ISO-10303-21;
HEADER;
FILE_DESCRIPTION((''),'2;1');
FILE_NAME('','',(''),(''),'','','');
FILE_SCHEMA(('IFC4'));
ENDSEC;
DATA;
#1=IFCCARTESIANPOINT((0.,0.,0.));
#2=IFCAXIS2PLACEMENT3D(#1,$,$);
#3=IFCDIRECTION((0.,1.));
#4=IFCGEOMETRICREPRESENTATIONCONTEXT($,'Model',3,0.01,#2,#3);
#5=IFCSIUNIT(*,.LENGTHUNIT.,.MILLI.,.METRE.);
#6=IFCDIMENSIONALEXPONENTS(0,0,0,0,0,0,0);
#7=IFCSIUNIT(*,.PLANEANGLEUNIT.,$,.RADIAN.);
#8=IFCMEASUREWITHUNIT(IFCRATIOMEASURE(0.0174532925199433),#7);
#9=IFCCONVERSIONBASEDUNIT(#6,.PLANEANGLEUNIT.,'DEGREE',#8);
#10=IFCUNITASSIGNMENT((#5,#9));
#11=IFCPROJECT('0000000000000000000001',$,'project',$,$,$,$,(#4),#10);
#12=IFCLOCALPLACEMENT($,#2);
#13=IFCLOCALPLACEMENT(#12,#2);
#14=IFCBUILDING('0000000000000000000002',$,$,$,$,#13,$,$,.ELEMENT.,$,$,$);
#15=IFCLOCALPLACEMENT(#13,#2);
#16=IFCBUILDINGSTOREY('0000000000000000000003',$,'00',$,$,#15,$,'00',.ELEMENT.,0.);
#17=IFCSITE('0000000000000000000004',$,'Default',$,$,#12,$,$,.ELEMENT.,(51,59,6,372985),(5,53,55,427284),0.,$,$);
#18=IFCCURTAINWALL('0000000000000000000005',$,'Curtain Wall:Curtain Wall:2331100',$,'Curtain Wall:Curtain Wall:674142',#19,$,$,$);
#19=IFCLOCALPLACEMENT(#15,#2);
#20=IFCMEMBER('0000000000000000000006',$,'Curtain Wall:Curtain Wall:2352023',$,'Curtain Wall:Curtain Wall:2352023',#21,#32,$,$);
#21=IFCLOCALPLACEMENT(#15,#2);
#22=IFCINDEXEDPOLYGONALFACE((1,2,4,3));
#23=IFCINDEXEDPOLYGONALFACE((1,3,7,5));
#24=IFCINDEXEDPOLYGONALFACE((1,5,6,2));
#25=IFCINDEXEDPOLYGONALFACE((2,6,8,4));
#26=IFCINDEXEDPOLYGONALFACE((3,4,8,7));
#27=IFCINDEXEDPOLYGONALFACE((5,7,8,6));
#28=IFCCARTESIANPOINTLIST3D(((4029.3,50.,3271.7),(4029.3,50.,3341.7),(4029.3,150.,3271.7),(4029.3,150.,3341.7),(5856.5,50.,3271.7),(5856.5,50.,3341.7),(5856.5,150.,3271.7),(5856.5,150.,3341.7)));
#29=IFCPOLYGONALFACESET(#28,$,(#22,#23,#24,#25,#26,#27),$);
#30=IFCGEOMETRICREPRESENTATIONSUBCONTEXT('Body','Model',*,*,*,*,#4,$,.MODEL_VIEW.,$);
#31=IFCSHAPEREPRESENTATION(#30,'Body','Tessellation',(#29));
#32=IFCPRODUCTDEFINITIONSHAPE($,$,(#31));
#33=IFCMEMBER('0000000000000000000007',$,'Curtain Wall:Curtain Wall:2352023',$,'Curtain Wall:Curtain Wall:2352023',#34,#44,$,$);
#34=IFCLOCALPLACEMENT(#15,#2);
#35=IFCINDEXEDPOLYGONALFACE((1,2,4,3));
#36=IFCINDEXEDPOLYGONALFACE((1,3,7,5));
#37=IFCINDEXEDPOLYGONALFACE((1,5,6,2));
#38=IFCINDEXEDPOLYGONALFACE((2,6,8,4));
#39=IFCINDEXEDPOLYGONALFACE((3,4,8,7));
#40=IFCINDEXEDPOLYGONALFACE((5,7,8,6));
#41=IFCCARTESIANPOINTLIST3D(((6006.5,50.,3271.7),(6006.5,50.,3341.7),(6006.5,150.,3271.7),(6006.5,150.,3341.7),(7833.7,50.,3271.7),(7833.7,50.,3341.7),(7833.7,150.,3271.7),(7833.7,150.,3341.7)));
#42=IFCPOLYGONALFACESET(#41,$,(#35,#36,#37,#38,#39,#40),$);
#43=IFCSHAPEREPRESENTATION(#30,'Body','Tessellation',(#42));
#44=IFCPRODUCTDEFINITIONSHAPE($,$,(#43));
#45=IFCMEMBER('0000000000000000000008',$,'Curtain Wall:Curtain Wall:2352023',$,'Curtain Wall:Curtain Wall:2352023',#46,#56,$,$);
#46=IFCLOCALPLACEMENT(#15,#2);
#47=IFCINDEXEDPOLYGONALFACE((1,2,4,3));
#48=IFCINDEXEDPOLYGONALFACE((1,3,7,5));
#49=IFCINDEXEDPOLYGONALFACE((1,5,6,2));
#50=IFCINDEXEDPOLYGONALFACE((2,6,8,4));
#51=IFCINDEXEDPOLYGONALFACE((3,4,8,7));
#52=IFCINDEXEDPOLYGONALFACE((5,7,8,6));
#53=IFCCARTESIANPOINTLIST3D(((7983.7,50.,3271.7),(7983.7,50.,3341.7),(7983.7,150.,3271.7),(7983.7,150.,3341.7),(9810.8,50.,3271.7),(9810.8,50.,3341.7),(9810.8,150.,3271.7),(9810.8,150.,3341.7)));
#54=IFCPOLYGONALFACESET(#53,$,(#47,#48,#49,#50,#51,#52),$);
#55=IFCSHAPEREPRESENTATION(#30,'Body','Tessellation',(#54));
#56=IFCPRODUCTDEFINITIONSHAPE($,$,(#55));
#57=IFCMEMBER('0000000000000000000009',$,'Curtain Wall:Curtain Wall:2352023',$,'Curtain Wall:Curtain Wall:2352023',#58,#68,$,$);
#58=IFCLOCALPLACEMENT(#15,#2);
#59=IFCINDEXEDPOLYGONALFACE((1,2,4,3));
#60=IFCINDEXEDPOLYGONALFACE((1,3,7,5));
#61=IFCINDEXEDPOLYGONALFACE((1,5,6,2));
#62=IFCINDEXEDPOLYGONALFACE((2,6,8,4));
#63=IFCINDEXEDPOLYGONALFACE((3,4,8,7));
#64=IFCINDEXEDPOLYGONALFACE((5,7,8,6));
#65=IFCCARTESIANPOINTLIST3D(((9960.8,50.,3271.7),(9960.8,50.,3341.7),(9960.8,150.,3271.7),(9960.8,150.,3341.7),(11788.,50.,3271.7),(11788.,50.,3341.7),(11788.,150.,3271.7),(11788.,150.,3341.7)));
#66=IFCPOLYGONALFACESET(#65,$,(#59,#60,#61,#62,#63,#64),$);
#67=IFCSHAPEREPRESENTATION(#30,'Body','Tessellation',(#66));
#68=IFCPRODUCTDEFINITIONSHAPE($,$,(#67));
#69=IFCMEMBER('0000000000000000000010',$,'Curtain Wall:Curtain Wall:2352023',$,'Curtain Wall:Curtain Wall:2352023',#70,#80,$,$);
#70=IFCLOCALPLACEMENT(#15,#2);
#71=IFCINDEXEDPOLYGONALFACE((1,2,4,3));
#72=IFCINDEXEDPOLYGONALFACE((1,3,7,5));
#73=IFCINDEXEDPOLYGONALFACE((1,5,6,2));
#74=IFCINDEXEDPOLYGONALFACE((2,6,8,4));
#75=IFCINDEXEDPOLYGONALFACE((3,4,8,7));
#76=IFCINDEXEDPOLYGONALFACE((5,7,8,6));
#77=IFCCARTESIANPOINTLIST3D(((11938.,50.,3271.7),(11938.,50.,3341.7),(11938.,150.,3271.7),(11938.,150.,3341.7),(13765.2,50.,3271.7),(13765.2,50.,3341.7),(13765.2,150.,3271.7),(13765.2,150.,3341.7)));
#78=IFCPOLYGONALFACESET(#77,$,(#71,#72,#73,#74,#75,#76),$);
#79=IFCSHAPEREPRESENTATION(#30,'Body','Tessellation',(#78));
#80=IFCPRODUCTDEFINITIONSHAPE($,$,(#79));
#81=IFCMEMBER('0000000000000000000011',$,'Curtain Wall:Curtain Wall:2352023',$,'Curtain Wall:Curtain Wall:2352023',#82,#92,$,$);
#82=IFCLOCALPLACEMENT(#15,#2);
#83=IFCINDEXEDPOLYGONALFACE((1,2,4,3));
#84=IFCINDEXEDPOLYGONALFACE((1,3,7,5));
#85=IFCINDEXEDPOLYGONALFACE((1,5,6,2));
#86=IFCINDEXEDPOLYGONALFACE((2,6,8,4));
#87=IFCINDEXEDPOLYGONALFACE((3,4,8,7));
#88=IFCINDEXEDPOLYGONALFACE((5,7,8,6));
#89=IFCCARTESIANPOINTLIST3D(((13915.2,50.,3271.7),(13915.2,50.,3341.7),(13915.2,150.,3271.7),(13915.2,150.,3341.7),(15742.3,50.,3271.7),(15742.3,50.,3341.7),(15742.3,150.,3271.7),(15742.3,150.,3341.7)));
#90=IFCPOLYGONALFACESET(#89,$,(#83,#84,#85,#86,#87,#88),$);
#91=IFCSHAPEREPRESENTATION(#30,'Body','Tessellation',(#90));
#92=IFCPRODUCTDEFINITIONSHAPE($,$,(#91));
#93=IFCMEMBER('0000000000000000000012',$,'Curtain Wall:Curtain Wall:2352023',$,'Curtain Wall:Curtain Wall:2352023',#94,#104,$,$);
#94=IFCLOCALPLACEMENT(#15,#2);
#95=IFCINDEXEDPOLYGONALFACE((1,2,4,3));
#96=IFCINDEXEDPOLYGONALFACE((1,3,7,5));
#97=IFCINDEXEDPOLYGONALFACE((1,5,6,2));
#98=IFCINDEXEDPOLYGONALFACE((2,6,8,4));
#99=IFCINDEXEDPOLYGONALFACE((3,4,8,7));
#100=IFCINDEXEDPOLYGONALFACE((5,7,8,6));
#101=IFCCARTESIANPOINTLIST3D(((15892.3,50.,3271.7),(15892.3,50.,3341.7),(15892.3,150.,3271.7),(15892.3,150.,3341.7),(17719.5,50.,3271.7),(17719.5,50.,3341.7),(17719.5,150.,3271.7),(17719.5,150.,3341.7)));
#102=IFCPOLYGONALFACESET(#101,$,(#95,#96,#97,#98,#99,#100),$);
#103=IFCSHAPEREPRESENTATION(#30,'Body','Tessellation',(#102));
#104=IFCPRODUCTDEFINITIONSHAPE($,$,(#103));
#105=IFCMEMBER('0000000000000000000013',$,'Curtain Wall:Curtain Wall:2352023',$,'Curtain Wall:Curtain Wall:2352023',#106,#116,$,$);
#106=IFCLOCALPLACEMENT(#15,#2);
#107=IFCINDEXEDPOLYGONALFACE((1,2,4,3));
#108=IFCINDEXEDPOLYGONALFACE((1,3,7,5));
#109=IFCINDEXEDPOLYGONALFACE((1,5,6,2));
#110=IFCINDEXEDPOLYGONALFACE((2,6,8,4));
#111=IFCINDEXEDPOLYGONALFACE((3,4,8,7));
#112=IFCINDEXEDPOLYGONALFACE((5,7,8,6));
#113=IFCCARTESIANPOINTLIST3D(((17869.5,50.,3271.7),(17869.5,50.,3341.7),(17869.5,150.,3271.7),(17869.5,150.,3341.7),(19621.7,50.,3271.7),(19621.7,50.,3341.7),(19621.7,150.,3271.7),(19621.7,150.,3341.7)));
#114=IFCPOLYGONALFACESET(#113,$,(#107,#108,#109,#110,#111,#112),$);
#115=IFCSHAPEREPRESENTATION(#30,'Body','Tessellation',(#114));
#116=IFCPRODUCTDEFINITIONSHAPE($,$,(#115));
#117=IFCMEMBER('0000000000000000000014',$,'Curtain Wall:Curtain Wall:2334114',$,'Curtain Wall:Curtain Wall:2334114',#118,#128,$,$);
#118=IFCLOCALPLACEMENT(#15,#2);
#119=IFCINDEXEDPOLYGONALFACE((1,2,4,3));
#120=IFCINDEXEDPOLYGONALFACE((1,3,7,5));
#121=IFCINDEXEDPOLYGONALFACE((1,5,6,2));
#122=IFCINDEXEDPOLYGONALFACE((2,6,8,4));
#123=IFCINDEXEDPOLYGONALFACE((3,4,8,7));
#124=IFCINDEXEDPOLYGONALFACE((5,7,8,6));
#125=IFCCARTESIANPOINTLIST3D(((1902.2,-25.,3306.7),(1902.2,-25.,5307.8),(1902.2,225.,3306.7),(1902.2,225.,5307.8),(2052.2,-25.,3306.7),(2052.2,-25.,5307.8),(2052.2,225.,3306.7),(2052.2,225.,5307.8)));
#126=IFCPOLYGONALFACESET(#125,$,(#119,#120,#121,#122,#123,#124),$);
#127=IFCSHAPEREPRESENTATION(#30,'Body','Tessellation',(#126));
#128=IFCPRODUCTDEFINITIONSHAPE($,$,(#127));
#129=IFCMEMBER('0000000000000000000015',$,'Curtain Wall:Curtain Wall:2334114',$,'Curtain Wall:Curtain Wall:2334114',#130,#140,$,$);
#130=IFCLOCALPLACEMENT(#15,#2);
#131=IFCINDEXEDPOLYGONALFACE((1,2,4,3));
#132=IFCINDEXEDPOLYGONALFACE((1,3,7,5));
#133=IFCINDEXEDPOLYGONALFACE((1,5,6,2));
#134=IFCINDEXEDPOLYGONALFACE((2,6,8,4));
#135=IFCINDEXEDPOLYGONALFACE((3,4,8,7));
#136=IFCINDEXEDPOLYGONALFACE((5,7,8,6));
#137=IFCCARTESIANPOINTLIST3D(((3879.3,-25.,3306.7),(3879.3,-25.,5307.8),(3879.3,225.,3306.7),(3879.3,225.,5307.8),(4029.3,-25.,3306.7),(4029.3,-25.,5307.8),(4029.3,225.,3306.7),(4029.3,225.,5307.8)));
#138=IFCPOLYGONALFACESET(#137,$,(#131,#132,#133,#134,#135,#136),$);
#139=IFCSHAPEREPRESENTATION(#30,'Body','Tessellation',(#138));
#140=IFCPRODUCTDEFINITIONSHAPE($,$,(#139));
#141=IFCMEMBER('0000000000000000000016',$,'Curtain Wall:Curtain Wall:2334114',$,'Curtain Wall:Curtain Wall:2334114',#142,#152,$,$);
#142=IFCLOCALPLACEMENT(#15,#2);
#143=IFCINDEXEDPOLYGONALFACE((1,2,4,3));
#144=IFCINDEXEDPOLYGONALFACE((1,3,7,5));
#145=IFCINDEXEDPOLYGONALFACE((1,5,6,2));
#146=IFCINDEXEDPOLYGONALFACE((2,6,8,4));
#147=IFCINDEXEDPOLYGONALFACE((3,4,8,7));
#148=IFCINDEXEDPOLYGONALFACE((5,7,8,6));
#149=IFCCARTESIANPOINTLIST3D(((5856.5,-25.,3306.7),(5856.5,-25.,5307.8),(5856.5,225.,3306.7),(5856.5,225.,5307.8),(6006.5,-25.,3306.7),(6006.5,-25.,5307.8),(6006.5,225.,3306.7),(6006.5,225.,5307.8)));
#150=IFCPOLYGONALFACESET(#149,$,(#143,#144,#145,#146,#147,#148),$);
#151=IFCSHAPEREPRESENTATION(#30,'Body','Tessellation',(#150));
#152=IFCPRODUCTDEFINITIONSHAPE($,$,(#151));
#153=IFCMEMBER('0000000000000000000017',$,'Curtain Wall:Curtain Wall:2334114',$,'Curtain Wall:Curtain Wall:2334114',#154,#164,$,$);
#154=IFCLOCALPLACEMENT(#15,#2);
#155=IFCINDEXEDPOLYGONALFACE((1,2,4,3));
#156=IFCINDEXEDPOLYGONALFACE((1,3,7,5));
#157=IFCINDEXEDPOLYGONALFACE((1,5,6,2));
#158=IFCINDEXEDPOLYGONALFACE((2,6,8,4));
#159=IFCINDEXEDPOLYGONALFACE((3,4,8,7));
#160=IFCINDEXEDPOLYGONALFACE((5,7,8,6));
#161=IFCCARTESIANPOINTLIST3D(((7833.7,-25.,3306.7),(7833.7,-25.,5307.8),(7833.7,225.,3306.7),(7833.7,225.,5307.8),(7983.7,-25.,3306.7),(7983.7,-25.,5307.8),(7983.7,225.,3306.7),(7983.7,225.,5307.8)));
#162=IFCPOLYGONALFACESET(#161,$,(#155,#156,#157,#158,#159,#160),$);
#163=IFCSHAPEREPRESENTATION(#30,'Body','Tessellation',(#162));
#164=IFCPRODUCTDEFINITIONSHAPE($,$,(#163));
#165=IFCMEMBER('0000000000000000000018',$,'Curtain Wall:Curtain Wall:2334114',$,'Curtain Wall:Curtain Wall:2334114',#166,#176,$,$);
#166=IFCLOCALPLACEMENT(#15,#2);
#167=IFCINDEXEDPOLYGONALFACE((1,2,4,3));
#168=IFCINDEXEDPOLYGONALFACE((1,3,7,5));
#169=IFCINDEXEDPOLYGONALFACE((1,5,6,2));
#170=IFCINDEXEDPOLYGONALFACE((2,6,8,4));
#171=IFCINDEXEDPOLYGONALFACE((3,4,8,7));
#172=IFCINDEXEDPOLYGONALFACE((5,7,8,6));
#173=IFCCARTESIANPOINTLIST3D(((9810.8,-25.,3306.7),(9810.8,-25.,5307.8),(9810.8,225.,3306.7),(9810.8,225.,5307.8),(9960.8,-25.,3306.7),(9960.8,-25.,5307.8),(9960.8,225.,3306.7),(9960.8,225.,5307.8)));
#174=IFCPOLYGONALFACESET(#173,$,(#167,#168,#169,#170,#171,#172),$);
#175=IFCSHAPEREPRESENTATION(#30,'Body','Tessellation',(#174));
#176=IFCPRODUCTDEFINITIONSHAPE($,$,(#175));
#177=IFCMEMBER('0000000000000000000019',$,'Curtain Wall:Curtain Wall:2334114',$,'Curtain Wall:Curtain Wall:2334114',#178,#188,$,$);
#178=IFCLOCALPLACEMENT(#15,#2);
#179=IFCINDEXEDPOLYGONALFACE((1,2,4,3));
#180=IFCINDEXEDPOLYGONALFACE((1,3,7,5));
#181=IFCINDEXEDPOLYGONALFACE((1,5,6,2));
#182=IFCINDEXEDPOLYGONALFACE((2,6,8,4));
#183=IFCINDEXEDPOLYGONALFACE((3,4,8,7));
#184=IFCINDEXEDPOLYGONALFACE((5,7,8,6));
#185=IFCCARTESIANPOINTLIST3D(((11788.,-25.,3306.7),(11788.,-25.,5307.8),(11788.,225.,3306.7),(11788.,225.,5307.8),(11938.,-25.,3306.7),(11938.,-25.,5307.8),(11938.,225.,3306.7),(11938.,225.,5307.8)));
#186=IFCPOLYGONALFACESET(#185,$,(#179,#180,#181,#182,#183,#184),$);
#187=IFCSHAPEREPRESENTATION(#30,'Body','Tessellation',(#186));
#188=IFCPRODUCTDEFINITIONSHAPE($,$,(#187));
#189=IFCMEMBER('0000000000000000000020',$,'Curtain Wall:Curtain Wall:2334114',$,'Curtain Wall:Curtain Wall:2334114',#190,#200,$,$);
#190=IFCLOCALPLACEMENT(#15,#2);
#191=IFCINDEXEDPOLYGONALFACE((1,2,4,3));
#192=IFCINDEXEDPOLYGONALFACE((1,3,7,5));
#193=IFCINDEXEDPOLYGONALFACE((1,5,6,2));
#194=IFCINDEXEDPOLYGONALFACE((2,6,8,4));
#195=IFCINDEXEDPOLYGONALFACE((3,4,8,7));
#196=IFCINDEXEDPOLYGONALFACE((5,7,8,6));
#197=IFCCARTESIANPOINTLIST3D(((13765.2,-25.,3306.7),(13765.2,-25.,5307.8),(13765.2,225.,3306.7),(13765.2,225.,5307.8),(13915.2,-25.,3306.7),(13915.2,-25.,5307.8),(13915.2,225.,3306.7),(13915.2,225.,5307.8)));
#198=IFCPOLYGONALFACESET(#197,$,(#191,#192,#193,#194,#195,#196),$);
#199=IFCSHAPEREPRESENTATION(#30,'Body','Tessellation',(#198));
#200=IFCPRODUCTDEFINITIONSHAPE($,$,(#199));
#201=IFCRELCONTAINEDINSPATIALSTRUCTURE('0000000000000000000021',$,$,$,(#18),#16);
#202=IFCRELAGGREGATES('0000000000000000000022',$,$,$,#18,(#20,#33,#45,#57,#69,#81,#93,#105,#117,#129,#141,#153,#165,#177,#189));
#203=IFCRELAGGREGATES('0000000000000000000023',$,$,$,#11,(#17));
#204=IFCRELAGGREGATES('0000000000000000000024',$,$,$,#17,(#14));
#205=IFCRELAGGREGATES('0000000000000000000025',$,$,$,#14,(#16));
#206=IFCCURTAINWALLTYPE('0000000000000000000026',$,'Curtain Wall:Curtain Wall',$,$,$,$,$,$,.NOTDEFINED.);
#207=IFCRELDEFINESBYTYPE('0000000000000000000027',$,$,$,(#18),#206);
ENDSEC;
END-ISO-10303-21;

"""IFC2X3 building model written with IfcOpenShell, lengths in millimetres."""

from ifc_helpers import new_model, entity, si_unit, converted_unit, direction, frame, frame_2d, origin, origin_2d_with_axis, place, context, subcontext, project, spatial, rectangle, extrude, type_object, element, aggregate, save


model = new_model("IFC2X3")

# Units and contexts
model_context = context("Model", 3, precision=0.01, world=origin(), true_north=direction((0.0, 1.0)))
body_context = subcontext(model_context, "Body", "Model", "MODEL_VIEW")
ifc_project = project(units=[si_unit("LENGTHUNIT", "METRE", prefix="MILLI"), converted_unit("PLANEANGLEUNIT", "DEGREE", entity("IfcRatioMeasure", 0.0174532925199433), si_unit("PLANEANGLEUNIT", "RADIAN"), dimensions=[0, 0, 0, 0, 0, 0, 0])], contexts=[model_context])

# Site, building, storey
site_placement = place(None, origin())
site = spatial("IfcSite", under=ifc_project, at=site_placement, Name="Default", CompositionType="ELEMENT", RefLatitude=(51, 59, 6, 372985), RefLongitude=(5, 53, 55, 427284), RefElevation=0.0)
building_placement = place(site_placement, origin())
building = spatial("IfcBuilding", under=site, at=building_placement, CompositionType="ELEMENT")
storey_placement = place(building_placement, origin())
storey = spatial("IfcBuildingStorey", under=building, at=storey_placement, Name="00", LongName="00", CompositionType="ELEMENT", Elevation=0.0)

# Curtain wall, members
curtain_wall_type = type_object("IfcCurtainWallType", Name="Curtain Wall:Curtain Wall", PredefinedType="NOTDEFINED")
curtain_wall_placement = place(storey_placement, origin())
curtain_wall = element("IfcCurtainWall", 1, at=curtain_wall_placement, inside=storey, type_object=curtain_wall_type, Name="Curtain Wall:Curtain Wall:2331100", ObjectType="Curtain Wall:Curtain Wall:674142")
member_1_placement = place(curtain_wall_placement, origin())
member_1 = element("IfcMember", 2, at=member_1_placement, Name="Curtain Wall:Curtain Wall:2352023", ObjectType="Curtain Wall:Curtain Wall:2352023", context=body_context, shape_type="SweptSolid", body=[
    extrude(rectangle(XDim=70.0, YDim=100.0, at=frame_2d((0.0, 0.0), x_axis=(1.0, 0.0))), frame((5856.5, 100.0, 3306.7), z_axis=(-1.0, 0.0, 0.0), x_axis=(0.0, 0.0, -1.0)), (0.0, 0.0, 1.0), 1827.2),
])
member_2_placement = place(curtain_wall_placement, origin())
member_2 = element("IfcMember", 3, at=member_2_placement, Name="Curtain Wall:Curtain Wall:2352023", ObjectType="Curtain Wall:Curtain Wall:2352023", context=body_context, shape_type="SweptSolid", body=[
    extrude(rectangle(XDim=70.0, YDim=100.0, at=frame_2d((0.0, 0.0), x_axis=(1.0, 0.0))), frame((7833.7, 100.0, 3306.7), z_axis=(-1.0, 0.0, 0.0), x_axis=(0.0, 0.0, -1.0)), (0.0, 0.0, 1.0), 1827.2),
])
member_3_placement = place(curtain_wall_placement, origin())
member_3 = element("IfcMember", 4, at=member_3_placement, Name="Curtain Wall:Curtain Wall:2352023", ObjectType="Curtain Wall:Curtain Wall:2352023", context=body_context, shape_type="SweptSolid", body=[
    extrude(rectangle(XDim=70.0, YDim=100.0, at=frame_2d((0.0, 0.0), x_axis=(1.0, 0.0))), frame((9810.8, 100.0, 3306.7), z_axis=(-1.0, 0.0, 0.0), x_axis=(0.0, 0.0, -1.0)), (0.0, 0.0, 1.0), 1827.2),
])
member_4_placement = place(curtain_wall_placement, origin())
member_4 = element("IfcMember", 5, at=member_4_placement, Name="Curtain Wall:Curtain Wall:2352023", ObjectType="Curtain Wall:Curtain Wall:2352023", context=body_context, shape_type="SweptSolid", body=[
    extrude(rectangle(XDim=70.0, YDim=100.0, at=frame_2d((0.0, 0.0), x_axis=(1.0, 0.0))), frame((11788.0, 100.0, 3306.7), z_axis=(-1.0, 0.0, 0.0), x_axis=(0.0, 0.0, -1.0)), (0.0, 0.0, 1.0), 1827.2),
])
member_5_placement = place(curtain_wall_placement, origin())
member_5 = element("IfcMember", 6, at=member_5_placement, Name="Curtain Wall:Curtain Wall:2352023", ObjectType="Curtain Wall:Curtain Wall:2352023", context=body_context, shape_type="SweptSolid", body=[
    extrude(rectangle(XDim=70.0, YDim=100.0, at=frame_2d((0.0, 0.0), x_axis=(1.0, 0.0))), frame((13765.2, 100.0, 3306.7), z_axis=(-1.0, 0.0, 0.0), x_axis=(0.0, 0.0, -1.0)), (0.0, 0.0, 1.0), 1827.2),
])
member_6_placement = place(curtain_wall_placement, origin())
member_6 = element("IfcMember", 7, at=member_6_placement, Name="Curtain Wall:Curtain Wall:2352023", ObjectType="Curtain Wall:Curtain Wall:2352023", context=body_context, shape_type="SweptSolid", body=[
    extrude(rectangle(XDim=70.0, YDim=100.0, at=frame_2d((0.0, 0.0), x_axis=(1.0, 0.0))), frame((15742.3, 100.0, 3306.7), z_axis=(-1.0, 0.0, 0.0), x_axis=(0.0, 0.0, -1.0)), (0.0, 0.0, 1.0), 1827.2),
])
member_7_placement = place(curtain_wall_placement, origin())
member_7 = element("IfcMember", 8, at=member_7_placement, Name="Curtain Wall:Curtain Wall:2352023", ObjectType="Curtain Wall:Curtain Wall:2352023", context=body_context, shape_type="SweptSolid", body=[
    extrude(rectangle(XDim=70.0, YDim=100.0, at=frame_2d((0.0, 0.0), x_axis=(1.0, 0.0))), frame((17719.5, 100.0, 3306.7), z_axis=(-1.0, 0.0, 0.0), x_axis=(0.0, 0.0, -1.0)), (0.0, 0.0, 1.0), 1827.2),
])
member_8_placement = place(curtain_wall_placement, origin())
member_8 = element("IfcMember", 9, at=member_8_placement, Name="Curtain Wall:Curtain Wall:2352023", ObjectType="Curtain Wall:Curtain Wall:2352023", context=body_context, shape_type="SweptSolid", body=[
    extrude(rectangle(XDim=70.0, YDim=100.0, at=frame_2d((0.0, 0.0), x_axis=(1.0, 0.0))), frame((19621.7, 100.0, 3306.7), z_axis=(-1.0, 0.0, 0.0), x_axis=(0.0, 0.0, -1.0)), (0.0, 0.0, 1.0), 1752.2),
])
member_9_placement = place(curtain_wall_placement, origin())
member_9 = element("IfcMember", 10, at=member_9_placement, Name="Curtain Wall:Curtain Wall:2334114", ObjectType="Curtain Wall:Curtain Wall:2334114", context=body_context, shape_type="SweptSolid", body=[
    extrude(rectangle(XDim=150.0, YDim=250.0, at=frame_2d((0.0, 0.0), x_axis=(1.0, 0.0))), frame((1977.2, 100.0, 3306.7), z_axis=(0.0, 0.0, 1.0), x_axis=(-1.0, 0.0, 0.0)), (0.0, 0.0, 1.0), 2001.1),
])
member_10_placement = place(curtain_wall_placement, origin())
member_10 = element("IfcMember", 11, at=member_10_placement, Name="Curtain Wall:Curtain Wall:2334114", ObjectType="Curtain Wall:Curtain Wall:2334114", context=body_context, shape_type="SweptSolid", body=[
    extrude(rectangle(XDim=150.0, YDim=250.0, at=frame_2d((0.0, 0.0), x_axis=(1.0, 0.0))), frame((3954.3, 100.0, 3306.7), z_axis=(0.0, 0.0, 1.0), x_axis=(-1.0, 0.0, 0.0)), (0.0, 0.0, 1.0), 2001.1),
])
member_11_placement = place(curtain_wall_placement, origin())
member_11 = element("IfcMember", 12, at=member_11_placement, Name="Curtain Wall:Curtain Wall:2334114", ObjectType="Curtain Wall:Curtain Wall:2334114", context=body_context, shape_type="SweptSolid", body=[
    extrude(rectangle(XDim=150.0, YDim=250.0, at=frame_2d((0.0, 0.0), x_axis=(1.0, 0.0))), frame((5931.5, 100.0, 3306.7), z_axis=(0.0, 0.0, 1.0), x_axis=(-1.0, 0.0, 0.0)), (0.0, 0.0, 1.0), 2001.1),
])
member_12_placement = place(curtain_wall_placement, origin())
member_12 = element("IfcMember", 13, at=member_12_placement, Name="Curtain Wall:Curtain Wall:2334114", ObjectType="Curtain Wall:Curtain Wall:2334114", context=body_context, shape_type="SweptSolid", body=[
    extrude(rectangle(XDim=150.0, YDim=250.0, at=frame_2d((0.0, 0.0), x_axis=(1.0, 0.0))), frame((7908.7, 100.0, 3306.7), z_axis=(0.0, 0.0, 1.0), x_axis=(-1.0, 0.0, 0.0)), (0.0, 0.0, 1.0), 2001.1),
])
member_13_placement = place(curtain_wall_placement, origin())
member_13 = element("IfcMember", 14, at=member_13_placement, Name="Curtain Wall:Curtain Wall:2334114", ObjectType="Curtain Wall:Curtain Wall:2334114", context=body_context, shape_type="SweptSolid", body=[
    extrude(rectangle(XDim=150.0, YDim=250.0, at=origin_2d_with_axis()), frame((9885.8, 100.0, 3306.7), z_axis=(0.0, 0.0, 1.0), x_axis=(-1.0, 0.0, 0.0)), (0.0, 0.0, 1.0), 2001.1),
])
member_14_placement = place(curtain_wall_placement, origin())
member_14 = element("IfcMember", 15, at=member_14_placement, Name="Curtain Wall:Curtain Wall:2334114", ObjectType="Curtain Wall:Curtain Wall:2334114", context=body_context, shape_type="SweptSolid", body=[
    extrude(rectangle(XDim=150.0, YDim=250.0, at=origin_2d_with_axis()), frame((11863.0, 100.0, 3306.7), z_axis=(0.0, 0.0, 1.0), x_axis=(-1.0, 0.0, 0.0)), (0.0, 0.0, 1.0), 2001.1),
])
member_15_placement = place(curtain_wall_placement, origin())
member_15 = element("IfcMember", 16, at=member_15_placement, Name="Curtain Wall:Curtain Wall:2334114", ObjectType="Curtain Wall:Curtain Wall:2334114", context=body_context, shape_type="SweptSolid", body=[
    extrude(rectangle(XDim=150.0, YDim=250.0, at=origin_2d_with_axis()), frame((13840.2, 100.0, 3306.7), z_axis=(0.0, 0.0, 1.0), x_axis=(-1.0, 0.0, 0.0)), (0.0, 0.0, 1.0), 2001.1),
])
aggregate(curtain_wall, [member_1, member_2, member_3, member_4, member_5, member_6, member_7, member_8, member_9, member_10, member_11, member_12, member_13, member_14, member_15])

save(model, "model.ifc")
